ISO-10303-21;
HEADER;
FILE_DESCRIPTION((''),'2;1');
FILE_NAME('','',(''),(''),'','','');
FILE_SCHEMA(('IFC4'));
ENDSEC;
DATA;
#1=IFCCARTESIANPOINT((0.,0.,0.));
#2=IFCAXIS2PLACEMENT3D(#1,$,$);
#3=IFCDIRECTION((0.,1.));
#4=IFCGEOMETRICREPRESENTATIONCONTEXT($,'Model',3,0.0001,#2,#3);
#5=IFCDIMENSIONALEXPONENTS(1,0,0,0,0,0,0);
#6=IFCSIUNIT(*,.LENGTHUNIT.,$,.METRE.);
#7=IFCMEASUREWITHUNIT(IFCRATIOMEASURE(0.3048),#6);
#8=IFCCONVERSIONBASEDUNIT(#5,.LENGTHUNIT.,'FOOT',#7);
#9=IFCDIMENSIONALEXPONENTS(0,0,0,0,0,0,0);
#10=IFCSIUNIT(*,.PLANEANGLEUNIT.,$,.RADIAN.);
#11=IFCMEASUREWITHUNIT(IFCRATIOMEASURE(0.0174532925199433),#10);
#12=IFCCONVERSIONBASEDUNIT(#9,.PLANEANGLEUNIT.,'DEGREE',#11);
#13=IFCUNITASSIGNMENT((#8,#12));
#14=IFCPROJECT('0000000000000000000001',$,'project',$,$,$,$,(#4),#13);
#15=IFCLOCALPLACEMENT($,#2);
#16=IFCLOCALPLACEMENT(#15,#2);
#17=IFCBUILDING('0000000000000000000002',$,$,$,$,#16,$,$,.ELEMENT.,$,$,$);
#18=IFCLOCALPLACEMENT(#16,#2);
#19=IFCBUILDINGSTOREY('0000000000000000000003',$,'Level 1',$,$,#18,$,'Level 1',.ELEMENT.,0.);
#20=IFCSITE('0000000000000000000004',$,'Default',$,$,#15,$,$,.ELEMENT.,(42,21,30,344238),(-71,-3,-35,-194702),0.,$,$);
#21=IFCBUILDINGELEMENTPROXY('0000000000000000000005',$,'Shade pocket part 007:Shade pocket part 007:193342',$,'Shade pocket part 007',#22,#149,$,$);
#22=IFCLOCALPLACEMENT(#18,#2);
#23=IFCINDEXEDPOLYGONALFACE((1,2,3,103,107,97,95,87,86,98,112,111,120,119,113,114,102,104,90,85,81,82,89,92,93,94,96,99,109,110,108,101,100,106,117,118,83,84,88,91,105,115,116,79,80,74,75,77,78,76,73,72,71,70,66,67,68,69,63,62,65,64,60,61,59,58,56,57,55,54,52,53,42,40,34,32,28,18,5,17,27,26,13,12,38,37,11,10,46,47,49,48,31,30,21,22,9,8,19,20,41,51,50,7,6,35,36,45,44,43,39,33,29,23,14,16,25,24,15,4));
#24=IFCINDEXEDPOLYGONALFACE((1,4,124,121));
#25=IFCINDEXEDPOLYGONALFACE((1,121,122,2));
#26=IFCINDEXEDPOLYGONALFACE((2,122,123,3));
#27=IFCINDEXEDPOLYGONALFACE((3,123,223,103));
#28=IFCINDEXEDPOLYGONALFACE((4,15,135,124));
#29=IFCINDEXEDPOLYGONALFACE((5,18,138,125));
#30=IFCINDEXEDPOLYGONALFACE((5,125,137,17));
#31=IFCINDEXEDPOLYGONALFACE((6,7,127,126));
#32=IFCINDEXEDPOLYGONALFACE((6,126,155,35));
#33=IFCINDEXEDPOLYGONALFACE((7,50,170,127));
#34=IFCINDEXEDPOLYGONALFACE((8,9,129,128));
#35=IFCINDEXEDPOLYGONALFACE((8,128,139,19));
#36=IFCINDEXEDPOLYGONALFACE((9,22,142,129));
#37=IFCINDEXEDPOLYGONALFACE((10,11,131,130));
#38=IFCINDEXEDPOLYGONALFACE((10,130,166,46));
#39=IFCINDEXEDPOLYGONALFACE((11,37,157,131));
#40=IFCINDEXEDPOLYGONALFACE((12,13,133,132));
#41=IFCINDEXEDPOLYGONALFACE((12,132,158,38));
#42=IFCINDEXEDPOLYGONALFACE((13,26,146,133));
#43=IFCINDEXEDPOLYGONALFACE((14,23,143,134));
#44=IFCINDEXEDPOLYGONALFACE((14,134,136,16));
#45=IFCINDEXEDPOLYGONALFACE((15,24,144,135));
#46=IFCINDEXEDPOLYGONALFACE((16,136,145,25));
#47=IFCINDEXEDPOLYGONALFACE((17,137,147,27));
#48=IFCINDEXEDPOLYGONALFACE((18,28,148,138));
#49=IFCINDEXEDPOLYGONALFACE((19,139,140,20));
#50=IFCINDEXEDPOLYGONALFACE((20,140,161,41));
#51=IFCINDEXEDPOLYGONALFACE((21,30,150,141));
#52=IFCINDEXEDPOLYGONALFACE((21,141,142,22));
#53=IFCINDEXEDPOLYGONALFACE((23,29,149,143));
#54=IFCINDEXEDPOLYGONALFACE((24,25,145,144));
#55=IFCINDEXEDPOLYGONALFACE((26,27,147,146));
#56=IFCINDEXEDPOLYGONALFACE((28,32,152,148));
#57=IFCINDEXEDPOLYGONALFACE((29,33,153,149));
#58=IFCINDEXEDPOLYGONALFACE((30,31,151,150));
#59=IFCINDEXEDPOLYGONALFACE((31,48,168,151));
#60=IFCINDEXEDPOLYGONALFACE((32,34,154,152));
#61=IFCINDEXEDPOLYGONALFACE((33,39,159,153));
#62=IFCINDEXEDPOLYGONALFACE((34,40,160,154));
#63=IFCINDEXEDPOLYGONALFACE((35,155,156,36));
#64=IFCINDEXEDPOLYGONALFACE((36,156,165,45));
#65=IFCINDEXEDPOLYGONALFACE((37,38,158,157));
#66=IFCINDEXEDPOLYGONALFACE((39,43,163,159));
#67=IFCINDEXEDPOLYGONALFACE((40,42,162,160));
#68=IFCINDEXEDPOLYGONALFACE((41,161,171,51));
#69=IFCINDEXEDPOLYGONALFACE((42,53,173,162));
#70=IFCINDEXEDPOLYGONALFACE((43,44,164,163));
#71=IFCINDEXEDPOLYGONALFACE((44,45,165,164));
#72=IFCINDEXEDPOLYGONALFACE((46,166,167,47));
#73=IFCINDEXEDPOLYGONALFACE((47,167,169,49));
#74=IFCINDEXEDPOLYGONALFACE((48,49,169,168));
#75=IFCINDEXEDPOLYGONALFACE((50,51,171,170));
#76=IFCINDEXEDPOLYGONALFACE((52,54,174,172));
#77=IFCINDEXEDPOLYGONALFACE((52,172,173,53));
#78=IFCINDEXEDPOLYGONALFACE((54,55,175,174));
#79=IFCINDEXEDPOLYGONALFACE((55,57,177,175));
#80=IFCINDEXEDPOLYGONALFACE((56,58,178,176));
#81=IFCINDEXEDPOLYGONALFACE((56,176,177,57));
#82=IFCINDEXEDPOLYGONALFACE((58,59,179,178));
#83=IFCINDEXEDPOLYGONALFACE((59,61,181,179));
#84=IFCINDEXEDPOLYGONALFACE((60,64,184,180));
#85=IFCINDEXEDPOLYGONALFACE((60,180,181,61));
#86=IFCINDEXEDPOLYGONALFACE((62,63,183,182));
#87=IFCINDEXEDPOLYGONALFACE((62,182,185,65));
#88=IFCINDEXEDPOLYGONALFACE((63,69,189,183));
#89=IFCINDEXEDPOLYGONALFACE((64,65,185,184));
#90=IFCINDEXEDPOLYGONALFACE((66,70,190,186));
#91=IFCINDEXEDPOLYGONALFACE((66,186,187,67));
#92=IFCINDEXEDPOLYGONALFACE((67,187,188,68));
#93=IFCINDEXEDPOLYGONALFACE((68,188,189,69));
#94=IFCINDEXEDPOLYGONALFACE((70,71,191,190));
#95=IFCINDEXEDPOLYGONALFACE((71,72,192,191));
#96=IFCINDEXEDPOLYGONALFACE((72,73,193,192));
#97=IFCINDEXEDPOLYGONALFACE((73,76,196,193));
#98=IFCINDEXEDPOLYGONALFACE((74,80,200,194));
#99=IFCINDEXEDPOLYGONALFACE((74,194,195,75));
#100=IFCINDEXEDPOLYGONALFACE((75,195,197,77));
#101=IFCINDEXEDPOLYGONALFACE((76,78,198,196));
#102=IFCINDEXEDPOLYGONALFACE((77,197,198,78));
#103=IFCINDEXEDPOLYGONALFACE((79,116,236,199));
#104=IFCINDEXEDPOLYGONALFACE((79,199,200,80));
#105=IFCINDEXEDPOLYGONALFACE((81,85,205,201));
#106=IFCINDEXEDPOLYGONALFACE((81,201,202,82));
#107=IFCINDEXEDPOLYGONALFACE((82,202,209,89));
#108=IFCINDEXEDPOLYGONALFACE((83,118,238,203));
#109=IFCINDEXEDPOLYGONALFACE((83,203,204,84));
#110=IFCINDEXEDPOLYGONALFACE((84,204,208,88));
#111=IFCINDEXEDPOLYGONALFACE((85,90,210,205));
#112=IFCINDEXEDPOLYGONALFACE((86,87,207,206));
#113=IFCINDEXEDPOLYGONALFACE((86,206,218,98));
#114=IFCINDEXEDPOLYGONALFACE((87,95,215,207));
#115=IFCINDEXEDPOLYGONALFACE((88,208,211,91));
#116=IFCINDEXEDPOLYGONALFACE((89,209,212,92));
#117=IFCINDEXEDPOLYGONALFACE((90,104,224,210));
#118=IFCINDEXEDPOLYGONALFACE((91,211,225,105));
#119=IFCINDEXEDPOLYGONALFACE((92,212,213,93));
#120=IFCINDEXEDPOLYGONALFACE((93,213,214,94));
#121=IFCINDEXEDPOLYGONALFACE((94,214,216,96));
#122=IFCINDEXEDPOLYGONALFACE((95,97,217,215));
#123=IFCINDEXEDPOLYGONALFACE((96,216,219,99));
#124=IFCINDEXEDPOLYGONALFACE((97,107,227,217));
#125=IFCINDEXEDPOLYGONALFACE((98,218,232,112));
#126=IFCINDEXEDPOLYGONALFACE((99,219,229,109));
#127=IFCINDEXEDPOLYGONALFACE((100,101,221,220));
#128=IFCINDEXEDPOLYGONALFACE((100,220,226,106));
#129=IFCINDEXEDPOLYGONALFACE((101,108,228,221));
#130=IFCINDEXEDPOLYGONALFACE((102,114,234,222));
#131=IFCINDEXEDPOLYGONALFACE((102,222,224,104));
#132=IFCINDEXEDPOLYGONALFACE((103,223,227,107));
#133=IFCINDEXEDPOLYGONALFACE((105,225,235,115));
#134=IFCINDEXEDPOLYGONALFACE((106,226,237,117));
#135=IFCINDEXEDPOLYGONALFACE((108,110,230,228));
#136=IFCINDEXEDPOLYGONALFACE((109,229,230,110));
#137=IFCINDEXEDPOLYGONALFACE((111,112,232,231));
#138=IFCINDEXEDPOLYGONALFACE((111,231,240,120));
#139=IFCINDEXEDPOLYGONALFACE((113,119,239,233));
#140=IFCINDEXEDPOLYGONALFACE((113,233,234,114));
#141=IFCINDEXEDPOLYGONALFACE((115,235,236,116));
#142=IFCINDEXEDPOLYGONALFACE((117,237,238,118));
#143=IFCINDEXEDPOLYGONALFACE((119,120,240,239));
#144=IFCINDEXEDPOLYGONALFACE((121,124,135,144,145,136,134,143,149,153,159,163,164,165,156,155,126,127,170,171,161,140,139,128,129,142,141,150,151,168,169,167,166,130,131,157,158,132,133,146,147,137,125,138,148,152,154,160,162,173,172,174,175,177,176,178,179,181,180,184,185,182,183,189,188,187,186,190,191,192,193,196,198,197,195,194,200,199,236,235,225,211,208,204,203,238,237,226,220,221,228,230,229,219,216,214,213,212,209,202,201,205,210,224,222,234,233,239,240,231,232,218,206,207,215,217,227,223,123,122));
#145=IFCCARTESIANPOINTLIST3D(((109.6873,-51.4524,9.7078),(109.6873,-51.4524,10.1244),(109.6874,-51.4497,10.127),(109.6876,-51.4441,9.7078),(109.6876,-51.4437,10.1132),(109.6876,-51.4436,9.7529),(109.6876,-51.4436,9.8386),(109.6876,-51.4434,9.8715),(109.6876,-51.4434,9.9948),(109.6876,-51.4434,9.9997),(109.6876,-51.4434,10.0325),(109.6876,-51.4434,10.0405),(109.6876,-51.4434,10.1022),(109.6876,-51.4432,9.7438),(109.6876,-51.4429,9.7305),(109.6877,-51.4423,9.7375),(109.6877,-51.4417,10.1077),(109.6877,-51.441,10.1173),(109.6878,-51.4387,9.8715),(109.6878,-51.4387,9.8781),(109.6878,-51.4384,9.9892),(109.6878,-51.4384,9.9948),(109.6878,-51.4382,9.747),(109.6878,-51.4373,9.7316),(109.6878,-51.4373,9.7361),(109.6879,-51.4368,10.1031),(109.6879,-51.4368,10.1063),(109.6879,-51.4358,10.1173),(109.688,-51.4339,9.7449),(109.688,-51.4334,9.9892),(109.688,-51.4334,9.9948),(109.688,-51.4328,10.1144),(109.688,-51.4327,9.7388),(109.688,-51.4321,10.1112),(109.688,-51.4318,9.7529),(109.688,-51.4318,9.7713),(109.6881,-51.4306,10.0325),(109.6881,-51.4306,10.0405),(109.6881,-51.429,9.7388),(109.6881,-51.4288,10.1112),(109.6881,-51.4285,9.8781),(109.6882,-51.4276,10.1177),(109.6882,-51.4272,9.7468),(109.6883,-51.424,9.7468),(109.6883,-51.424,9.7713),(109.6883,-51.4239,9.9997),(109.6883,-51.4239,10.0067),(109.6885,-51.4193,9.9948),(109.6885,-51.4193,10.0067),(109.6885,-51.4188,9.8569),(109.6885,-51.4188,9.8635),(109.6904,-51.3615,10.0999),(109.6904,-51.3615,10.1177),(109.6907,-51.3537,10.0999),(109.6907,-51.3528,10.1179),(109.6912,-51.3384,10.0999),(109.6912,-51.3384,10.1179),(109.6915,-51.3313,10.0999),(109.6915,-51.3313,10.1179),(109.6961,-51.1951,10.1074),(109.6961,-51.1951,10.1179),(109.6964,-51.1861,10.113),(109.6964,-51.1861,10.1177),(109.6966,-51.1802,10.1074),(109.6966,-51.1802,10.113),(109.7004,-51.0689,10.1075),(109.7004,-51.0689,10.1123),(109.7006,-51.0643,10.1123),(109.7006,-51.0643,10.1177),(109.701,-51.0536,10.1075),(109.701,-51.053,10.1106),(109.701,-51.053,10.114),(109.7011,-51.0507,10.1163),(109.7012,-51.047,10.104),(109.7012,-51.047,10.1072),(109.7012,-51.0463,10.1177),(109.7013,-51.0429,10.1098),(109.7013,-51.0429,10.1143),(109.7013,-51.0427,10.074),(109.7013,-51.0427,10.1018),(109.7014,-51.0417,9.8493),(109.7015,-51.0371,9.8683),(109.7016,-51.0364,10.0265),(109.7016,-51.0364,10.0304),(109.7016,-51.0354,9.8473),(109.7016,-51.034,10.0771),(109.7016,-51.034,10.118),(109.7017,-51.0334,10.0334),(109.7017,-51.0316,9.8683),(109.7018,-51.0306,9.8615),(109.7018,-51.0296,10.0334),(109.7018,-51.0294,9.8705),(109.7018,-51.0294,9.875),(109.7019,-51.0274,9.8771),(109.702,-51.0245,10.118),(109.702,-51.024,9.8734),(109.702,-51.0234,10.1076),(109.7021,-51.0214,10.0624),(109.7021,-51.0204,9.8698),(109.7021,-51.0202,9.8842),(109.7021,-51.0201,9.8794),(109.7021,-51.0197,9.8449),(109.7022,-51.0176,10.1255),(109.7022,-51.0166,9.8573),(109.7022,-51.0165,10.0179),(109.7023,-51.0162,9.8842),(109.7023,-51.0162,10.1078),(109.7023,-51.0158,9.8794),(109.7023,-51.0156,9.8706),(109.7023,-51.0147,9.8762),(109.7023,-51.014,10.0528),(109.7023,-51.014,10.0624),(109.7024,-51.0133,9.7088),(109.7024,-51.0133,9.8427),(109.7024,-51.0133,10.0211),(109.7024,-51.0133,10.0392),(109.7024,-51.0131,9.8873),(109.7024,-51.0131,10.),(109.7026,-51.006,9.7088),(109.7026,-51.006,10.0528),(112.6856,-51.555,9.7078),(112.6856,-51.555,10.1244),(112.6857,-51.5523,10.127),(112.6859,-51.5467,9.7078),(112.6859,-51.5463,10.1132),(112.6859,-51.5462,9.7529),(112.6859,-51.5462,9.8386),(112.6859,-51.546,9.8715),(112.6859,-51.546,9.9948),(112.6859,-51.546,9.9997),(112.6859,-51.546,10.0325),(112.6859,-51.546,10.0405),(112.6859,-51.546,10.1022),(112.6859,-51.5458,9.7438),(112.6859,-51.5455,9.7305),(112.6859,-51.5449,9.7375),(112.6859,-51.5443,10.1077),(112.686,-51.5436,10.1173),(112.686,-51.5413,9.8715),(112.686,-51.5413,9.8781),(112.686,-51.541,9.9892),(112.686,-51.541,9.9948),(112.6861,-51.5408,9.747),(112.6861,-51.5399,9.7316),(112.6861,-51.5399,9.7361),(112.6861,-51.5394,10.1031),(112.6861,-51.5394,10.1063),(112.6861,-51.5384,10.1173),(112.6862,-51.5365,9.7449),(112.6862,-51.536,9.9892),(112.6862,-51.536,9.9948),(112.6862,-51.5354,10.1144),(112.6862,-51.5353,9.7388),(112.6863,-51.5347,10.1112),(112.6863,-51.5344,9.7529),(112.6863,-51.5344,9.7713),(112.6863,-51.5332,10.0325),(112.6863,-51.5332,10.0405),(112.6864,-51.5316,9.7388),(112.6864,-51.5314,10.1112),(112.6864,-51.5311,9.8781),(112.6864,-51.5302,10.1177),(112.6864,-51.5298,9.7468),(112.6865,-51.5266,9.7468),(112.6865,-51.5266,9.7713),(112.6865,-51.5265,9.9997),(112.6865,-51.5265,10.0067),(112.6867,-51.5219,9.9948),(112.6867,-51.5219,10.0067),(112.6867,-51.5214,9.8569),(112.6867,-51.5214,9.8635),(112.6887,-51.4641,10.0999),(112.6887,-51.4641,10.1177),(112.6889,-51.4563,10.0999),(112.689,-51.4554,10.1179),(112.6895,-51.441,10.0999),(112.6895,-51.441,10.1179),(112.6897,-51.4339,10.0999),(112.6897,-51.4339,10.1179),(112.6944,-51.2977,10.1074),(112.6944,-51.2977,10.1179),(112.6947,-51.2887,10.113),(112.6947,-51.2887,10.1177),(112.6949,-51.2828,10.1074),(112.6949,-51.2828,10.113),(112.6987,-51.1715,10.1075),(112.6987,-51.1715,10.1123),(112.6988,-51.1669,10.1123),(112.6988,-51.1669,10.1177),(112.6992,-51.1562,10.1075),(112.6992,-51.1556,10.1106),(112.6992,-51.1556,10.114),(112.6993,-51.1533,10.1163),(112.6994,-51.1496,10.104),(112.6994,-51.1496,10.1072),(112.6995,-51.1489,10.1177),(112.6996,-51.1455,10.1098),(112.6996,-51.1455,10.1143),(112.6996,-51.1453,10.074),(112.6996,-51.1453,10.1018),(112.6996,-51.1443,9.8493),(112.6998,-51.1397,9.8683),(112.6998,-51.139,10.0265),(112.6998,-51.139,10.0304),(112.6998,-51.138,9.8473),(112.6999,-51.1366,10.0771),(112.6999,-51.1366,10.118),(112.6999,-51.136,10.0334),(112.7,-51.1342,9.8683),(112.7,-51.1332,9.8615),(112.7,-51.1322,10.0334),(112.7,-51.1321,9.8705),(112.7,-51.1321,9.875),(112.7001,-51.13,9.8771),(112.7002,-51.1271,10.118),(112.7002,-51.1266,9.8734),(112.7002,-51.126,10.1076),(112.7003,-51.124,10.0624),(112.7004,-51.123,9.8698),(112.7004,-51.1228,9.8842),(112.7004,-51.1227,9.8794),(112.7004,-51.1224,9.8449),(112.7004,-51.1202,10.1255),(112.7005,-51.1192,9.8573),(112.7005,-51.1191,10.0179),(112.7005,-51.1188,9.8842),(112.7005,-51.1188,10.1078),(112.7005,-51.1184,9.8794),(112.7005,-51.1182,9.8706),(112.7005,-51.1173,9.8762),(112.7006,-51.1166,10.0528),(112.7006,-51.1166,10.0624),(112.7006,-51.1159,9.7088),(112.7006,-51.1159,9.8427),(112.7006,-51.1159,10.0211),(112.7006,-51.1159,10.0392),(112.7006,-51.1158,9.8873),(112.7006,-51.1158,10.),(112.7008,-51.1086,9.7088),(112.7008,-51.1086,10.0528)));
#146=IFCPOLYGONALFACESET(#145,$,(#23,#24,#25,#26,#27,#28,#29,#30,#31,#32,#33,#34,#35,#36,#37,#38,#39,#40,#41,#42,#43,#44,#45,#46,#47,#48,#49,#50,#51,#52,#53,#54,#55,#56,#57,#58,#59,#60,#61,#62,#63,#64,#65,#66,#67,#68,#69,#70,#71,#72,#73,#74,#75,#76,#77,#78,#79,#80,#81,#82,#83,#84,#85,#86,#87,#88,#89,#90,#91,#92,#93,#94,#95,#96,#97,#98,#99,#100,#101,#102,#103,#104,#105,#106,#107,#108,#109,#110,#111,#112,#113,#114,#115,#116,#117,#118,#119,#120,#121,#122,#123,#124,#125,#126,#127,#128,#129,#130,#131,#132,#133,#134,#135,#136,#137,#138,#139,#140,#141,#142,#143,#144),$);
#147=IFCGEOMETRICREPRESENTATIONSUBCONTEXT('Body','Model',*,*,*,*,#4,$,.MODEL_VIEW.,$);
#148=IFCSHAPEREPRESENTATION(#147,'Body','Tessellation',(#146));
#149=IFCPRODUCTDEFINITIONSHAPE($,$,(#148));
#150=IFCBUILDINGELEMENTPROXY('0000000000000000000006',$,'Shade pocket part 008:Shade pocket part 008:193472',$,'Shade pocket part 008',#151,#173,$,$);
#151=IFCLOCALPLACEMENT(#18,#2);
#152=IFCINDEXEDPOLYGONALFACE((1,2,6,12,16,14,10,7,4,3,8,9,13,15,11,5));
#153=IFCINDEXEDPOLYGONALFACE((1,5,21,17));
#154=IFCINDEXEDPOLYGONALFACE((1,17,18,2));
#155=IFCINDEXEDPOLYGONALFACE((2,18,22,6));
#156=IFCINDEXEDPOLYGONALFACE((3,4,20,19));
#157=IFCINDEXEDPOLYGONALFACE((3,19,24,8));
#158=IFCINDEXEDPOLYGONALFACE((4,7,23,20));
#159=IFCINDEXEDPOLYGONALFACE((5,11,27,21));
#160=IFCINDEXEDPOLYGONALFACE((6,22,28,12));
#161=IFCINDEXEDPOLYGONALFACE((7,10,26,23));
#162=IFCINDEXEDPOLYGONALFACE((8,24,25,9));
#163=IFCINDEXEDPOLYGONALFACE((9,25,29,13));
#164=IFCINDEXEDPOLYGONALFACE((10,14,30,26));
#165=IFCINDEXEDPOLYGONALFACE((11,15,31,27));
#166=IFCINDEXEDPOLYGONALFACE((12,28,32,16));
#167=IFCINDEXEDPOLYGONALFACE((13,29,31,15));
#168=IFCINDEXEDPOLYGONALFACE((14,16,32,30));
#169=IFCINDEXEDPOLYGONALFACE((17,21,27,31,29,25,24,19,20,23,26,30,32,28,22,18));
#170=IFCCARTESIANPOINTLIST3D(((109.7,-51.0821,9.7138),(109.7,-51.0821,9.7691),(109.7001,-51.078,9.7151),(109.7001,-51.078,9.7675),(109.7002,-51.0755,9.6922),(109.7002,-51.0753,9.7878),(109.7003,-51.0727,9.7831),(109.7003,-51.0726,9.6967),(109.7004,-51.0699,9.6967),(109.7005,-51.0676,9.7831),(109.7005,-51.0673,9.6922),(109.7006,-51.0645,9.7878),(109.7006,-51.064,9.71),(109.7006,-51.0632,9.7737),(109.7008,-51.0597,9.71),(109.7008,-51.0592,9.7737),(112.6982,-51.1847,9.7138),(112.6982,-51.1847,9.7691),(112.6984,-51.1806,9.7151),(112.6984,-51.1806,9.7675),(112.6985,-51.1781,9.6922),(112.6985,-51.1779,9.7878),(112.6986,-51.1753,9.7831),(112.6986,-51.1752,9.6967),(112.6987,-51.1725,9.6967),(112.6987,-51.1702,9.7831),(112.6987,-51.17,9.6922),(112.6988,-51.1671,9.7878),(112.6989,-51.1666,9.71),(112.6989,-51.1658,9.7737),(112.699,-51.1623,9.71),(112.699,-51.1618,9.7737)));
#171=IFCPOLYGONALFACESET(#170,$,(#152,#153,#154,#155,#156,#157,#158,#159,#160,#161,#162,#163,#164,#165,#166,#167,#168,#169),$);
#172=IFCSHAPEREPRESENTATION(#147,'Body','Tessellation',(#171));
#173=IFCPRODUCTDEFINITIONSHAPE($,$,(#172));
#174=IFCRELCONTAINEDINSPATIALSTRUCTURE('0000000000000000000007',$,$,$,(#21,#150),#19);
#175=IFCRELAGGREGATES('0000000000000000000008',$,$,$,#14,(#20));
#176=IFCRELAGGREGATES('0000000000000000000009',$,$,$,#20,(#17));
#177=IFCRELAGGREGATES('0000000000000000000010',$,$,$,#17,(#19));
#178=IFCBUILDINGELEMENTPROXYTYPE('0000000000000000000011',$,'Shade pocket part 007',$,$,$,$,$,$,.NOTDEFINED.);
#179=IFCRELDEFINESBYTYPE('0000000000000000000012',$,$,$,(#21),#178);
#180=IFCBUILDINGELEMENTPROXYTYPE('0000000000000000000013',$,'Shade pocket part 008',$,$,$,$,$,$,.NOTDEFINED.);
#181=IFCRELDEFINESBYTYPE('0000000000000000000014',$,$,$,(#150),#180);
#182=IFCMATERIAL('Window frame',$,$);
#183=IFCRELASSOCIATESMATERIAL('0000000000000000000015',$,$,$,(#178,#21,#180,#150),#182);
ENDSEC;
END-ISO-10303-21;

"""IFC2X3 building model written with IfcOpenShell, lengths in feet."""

from ifc_helpers import new_model, entity, si_unit, converted_unit, direction, frame, origin, place, context, subcontext, project, spatial, polyline, outline, extrude, source, transform, mapped, material, type_object, type_shapes, element, save


model = new_model("IFC2X3")

# Units and contexts
model_context = context("Model", 3, precision=0.0001, world=origin(), true_north=direction((0.0, 1.0)))
body_context = subcontext(model_context, "Body", "Model", "MODEL_VIEW")
ifc_project = project(units=[converted_unit("LENGTHUNIT", "FOOT", entity("IfcRatioMeasure", 0.3048), si_unit("LENGTHUNIT", "METRE"), dimensions=[1, 0, 0, 0, 0, 0, 0]), converted_unit("PLANEANGLEUNIT", "DEGREE", entity("IfcRatioMeasure", 0.0174532925199433), si_unit("PLANEANGLEUNIT", "RADIAN"), dimensions=[0, 0, 0, 0, 0, 0, 0])], contexts=[model_context])

# Site, building, storey
site_placement = place(None, origin())
site = spatial("IfcSite", under=ifc_project, at=site_placement, Name="Default", CompositionType="ELEMENT", RefLatitude=(42, 21, 30, 344238), RefLongitude=(-71, -3, -35, -194702), RefElevation=0.0)
building_placement = place(site_placement, origin())
building = spatial("IfcBuilding", under=site, at=building_placement, CompositionType="ELEMENT")
storey_placement = place(building_placement, origin())
storey = spatial("IfcBuildingStorey", under=building, at=storey_placement, Name="Level 1", LongName="Level 1", CompositionType="ELEMENT", Elevation=0.0)

# Building element proxies
ifc_material_1 = material(Name="Window frame")
building_element_proxy_type_1 = type_object("IfcBuildingElementProxyType", Name="Shade pocket part 007", PredefinedType="NOTDEFINED", material=ifc_material_1)
shared_shape_1 = source(origin(), body_context, "Body", "SweptSolid", [
    extrude(outline(polyline([(0.2118, 0.1242), (0.219, 0.1242), (0.2181, 0.1419), (-0.2141, 0.1556), (-0.2168, 0.153), (-0.2285, -0.2634), (-0.2201, -0.2636), (-0.2184, -0.2409), (-0.2127, -0.2401), (-0.2126, -0.2355), (-0.2176, -0.234), (-0.2183, -0.2277), (-0.2132, -0.2246), (-0.2089, -0.2268), (-0.2079, -0.233), (-0.2042, -0.2331), (-0.2022, -0.2251), (-0.199, -0.2252), (-0.1983, -0.2007), (-0.2061, -0.2005), (-0.2066, -0.2189), (-0.2185, -0.2186), (-0.216, -0.1329), (-0.1907, -0.1153), (-0.1905, -0.1087), (-0.1998, -0.0938), (-0.21, -0.0935), (-0.2102, -0.1001), (-0.2149, -0.1), (-0.2115, 0.0233), (-0.2064, 0.0231), (-0.2066, 0.0175), (-0.2016, 0.0173), (-0.2014, 0.023), (-0.1873, 0.0226), (-0.187, 0.0344), (-0.1916, 0.0346), (-0.1918, 0.0276), (-0.2113, 0.0281), (-0.2104, 0.0609), (-0.1976, 0.0605), (-0.1973, 0.0686), (-0.2102, 0.0689), (-0.2084, 0.1306), (-0.2018, 0.1313), (-0.2017, 0.1345), (-0.2066, 0.136), (-0.2085, 0.1416), (-0.2056, 0.1456), (-0.2004, 0.1455), (-0.1975, 0.1425), (-0.1969, 0.1393), (-0.1936, 0.1392), (-0.1922, 0.1457), (-0.1261, 0.1438), (-0.1266, 0.126), (-0.1188, 0.1258), (-0.1174, 0.1438), (-0.103, 0.1434), (-0.1035, 0.1253), (-0.0964, 0.1252), (-0.0959, 0.1432), (0.0404, 0.1394), (0.0401, 0.1288), (0.0549, 0.1284), (0.0551, 0.134), (0.0492, 0.1341), (0.0493, 0.1389), (0.1711, 0.1355), (0.171, 0.13), (0.1665, 0.1302), (0.1663, 0.1254), (0.1816, 0.125), (0.1823, 0.128), (0.1824, 0.1315), (0.1848, 0.1337), (0.1892, 0.135), (0.1925, 0.1314), (0.1924, 0.1269), (0.1882, 0.1245), (0.1881, 0.1212), (0.1924, 0.1189), (0.1916, 0.0911), (0.22, 0.0556), (0.2195, 0.0374), (0.2162, 0.0343), (0.2036, 0.0502), (0.1997, 0.0504), (0.1966, 0.0474), (0.1965, 0.0435), (0.219, 0.0164), (0.2159, -0.0963), (0.2127, -0.0993), (0.2087, -0.0992), (0.2087, -0.104), (0.213, -0.1041), (0.214, -0.1073), (0.213, -0.1129), (0.2082, -0.1136), (0.2047, -0.1099), (0.2014, -0.1061), (0.1992, -0.1081), (0.1991, -0.1126), (0.1969, -0.1147), (0.1914, -0.1146), (0.1863, -0.1335), (0.1925, -0.1356), (0.1977, -0.1216), (0.2116, -0.1262), (0.2081, -0.1385), (0.2145, -0.1409), (0.2107, -0.2747), (0.218, -0.2749), (0.2277, 0.069), (0.2197, 0.0692), (0.2199, 0.0788), (0.2125, 0.079), (0.2004, 0.094), (0.2015, 0.1349), (0.211, 0.1347), (0.2118, 0.1242)])), frame((109.6949, -51.2315, 9.9775), z_axis=(0.999415, -0.034202, 0.0), x_axis=(0.034188, 0.999022, 0.028044)), (0.0, 0.0, 1.0), 3.0),
])
type_shapes(building_element_proxy_type_1, [shared_shape_1])
proxy_1_placement = place(storey_placement, origin())
element("IfcBuildingElementProxy", 1, at=proxy_1_placement, inside=storey, type_object=building_element_proxy_type_1, material=ifc_material_1, Name="Shade pocket part 007:Shade pocket part 007:193342", ObjectType="Shade pocket part 007", context=body_context, shape_type="MappedRepresentation", body=[
    mapped(shared_shape_1, transform((0.0, 0.0, 0.0), scale=1.0)),
])
building_element_proxy_type_2 = type_object("IfcBuildingElementProxyType", Name="Shade pocket part 008", PredefinedType="NOTDEFINED", material=ifc_material_1)
shared_shape_2 = source(origin(), body_context, "Body", "SweptSolid", [
    extrude(outline(polyline([(0.0081, 0.0327), (0.0121, 0.0327), (0.0071, 0.0469), (-0.0038, 0.0471), (-0.0109, 0.0285), (-0.0118, -0.0268), (-0.0056, -0.0485), (0.0026, -0.0487), (0.0105, -0.0309), (0.0062, -0.0309), (0.0001, -0.0441), (-0.0026, -0.044), (-0.0077, -0.0256), (-0.0068, 0.0269), (-0.0013, 0.0423), (0.0038, 0.0422), (0.0081, 0.0327)])), frame((109.7004, -51.0707, 9.7408), z_axis=(0.999415, -0.034202, 0.0), x_axis=(0.034197, 0.999278, 0.016573)), (0.0, 0.0, 1.0), 3.0),
])
type_shapes(building_element_proxy_type_2, [shared_shape_2])
proxy_2_placement = place(storey_placement, origin())
element("IfcBuildingElementProxy", 2, at=proxy_2_placement, inside=storey, type_object=building_element_proxy_type_2, material=ifc_material_1, Name="Shade pocket part 008:Shade pocket part 008:193472", ObjectType="Shade pocket part 008", context=body_context, shape_type="MappedRepresentation", body=[
    mapped(shared_shape_2, transform((0.0, 0.0, 0.0), scale=1.0)),
])

save(model, "model.ifc")
